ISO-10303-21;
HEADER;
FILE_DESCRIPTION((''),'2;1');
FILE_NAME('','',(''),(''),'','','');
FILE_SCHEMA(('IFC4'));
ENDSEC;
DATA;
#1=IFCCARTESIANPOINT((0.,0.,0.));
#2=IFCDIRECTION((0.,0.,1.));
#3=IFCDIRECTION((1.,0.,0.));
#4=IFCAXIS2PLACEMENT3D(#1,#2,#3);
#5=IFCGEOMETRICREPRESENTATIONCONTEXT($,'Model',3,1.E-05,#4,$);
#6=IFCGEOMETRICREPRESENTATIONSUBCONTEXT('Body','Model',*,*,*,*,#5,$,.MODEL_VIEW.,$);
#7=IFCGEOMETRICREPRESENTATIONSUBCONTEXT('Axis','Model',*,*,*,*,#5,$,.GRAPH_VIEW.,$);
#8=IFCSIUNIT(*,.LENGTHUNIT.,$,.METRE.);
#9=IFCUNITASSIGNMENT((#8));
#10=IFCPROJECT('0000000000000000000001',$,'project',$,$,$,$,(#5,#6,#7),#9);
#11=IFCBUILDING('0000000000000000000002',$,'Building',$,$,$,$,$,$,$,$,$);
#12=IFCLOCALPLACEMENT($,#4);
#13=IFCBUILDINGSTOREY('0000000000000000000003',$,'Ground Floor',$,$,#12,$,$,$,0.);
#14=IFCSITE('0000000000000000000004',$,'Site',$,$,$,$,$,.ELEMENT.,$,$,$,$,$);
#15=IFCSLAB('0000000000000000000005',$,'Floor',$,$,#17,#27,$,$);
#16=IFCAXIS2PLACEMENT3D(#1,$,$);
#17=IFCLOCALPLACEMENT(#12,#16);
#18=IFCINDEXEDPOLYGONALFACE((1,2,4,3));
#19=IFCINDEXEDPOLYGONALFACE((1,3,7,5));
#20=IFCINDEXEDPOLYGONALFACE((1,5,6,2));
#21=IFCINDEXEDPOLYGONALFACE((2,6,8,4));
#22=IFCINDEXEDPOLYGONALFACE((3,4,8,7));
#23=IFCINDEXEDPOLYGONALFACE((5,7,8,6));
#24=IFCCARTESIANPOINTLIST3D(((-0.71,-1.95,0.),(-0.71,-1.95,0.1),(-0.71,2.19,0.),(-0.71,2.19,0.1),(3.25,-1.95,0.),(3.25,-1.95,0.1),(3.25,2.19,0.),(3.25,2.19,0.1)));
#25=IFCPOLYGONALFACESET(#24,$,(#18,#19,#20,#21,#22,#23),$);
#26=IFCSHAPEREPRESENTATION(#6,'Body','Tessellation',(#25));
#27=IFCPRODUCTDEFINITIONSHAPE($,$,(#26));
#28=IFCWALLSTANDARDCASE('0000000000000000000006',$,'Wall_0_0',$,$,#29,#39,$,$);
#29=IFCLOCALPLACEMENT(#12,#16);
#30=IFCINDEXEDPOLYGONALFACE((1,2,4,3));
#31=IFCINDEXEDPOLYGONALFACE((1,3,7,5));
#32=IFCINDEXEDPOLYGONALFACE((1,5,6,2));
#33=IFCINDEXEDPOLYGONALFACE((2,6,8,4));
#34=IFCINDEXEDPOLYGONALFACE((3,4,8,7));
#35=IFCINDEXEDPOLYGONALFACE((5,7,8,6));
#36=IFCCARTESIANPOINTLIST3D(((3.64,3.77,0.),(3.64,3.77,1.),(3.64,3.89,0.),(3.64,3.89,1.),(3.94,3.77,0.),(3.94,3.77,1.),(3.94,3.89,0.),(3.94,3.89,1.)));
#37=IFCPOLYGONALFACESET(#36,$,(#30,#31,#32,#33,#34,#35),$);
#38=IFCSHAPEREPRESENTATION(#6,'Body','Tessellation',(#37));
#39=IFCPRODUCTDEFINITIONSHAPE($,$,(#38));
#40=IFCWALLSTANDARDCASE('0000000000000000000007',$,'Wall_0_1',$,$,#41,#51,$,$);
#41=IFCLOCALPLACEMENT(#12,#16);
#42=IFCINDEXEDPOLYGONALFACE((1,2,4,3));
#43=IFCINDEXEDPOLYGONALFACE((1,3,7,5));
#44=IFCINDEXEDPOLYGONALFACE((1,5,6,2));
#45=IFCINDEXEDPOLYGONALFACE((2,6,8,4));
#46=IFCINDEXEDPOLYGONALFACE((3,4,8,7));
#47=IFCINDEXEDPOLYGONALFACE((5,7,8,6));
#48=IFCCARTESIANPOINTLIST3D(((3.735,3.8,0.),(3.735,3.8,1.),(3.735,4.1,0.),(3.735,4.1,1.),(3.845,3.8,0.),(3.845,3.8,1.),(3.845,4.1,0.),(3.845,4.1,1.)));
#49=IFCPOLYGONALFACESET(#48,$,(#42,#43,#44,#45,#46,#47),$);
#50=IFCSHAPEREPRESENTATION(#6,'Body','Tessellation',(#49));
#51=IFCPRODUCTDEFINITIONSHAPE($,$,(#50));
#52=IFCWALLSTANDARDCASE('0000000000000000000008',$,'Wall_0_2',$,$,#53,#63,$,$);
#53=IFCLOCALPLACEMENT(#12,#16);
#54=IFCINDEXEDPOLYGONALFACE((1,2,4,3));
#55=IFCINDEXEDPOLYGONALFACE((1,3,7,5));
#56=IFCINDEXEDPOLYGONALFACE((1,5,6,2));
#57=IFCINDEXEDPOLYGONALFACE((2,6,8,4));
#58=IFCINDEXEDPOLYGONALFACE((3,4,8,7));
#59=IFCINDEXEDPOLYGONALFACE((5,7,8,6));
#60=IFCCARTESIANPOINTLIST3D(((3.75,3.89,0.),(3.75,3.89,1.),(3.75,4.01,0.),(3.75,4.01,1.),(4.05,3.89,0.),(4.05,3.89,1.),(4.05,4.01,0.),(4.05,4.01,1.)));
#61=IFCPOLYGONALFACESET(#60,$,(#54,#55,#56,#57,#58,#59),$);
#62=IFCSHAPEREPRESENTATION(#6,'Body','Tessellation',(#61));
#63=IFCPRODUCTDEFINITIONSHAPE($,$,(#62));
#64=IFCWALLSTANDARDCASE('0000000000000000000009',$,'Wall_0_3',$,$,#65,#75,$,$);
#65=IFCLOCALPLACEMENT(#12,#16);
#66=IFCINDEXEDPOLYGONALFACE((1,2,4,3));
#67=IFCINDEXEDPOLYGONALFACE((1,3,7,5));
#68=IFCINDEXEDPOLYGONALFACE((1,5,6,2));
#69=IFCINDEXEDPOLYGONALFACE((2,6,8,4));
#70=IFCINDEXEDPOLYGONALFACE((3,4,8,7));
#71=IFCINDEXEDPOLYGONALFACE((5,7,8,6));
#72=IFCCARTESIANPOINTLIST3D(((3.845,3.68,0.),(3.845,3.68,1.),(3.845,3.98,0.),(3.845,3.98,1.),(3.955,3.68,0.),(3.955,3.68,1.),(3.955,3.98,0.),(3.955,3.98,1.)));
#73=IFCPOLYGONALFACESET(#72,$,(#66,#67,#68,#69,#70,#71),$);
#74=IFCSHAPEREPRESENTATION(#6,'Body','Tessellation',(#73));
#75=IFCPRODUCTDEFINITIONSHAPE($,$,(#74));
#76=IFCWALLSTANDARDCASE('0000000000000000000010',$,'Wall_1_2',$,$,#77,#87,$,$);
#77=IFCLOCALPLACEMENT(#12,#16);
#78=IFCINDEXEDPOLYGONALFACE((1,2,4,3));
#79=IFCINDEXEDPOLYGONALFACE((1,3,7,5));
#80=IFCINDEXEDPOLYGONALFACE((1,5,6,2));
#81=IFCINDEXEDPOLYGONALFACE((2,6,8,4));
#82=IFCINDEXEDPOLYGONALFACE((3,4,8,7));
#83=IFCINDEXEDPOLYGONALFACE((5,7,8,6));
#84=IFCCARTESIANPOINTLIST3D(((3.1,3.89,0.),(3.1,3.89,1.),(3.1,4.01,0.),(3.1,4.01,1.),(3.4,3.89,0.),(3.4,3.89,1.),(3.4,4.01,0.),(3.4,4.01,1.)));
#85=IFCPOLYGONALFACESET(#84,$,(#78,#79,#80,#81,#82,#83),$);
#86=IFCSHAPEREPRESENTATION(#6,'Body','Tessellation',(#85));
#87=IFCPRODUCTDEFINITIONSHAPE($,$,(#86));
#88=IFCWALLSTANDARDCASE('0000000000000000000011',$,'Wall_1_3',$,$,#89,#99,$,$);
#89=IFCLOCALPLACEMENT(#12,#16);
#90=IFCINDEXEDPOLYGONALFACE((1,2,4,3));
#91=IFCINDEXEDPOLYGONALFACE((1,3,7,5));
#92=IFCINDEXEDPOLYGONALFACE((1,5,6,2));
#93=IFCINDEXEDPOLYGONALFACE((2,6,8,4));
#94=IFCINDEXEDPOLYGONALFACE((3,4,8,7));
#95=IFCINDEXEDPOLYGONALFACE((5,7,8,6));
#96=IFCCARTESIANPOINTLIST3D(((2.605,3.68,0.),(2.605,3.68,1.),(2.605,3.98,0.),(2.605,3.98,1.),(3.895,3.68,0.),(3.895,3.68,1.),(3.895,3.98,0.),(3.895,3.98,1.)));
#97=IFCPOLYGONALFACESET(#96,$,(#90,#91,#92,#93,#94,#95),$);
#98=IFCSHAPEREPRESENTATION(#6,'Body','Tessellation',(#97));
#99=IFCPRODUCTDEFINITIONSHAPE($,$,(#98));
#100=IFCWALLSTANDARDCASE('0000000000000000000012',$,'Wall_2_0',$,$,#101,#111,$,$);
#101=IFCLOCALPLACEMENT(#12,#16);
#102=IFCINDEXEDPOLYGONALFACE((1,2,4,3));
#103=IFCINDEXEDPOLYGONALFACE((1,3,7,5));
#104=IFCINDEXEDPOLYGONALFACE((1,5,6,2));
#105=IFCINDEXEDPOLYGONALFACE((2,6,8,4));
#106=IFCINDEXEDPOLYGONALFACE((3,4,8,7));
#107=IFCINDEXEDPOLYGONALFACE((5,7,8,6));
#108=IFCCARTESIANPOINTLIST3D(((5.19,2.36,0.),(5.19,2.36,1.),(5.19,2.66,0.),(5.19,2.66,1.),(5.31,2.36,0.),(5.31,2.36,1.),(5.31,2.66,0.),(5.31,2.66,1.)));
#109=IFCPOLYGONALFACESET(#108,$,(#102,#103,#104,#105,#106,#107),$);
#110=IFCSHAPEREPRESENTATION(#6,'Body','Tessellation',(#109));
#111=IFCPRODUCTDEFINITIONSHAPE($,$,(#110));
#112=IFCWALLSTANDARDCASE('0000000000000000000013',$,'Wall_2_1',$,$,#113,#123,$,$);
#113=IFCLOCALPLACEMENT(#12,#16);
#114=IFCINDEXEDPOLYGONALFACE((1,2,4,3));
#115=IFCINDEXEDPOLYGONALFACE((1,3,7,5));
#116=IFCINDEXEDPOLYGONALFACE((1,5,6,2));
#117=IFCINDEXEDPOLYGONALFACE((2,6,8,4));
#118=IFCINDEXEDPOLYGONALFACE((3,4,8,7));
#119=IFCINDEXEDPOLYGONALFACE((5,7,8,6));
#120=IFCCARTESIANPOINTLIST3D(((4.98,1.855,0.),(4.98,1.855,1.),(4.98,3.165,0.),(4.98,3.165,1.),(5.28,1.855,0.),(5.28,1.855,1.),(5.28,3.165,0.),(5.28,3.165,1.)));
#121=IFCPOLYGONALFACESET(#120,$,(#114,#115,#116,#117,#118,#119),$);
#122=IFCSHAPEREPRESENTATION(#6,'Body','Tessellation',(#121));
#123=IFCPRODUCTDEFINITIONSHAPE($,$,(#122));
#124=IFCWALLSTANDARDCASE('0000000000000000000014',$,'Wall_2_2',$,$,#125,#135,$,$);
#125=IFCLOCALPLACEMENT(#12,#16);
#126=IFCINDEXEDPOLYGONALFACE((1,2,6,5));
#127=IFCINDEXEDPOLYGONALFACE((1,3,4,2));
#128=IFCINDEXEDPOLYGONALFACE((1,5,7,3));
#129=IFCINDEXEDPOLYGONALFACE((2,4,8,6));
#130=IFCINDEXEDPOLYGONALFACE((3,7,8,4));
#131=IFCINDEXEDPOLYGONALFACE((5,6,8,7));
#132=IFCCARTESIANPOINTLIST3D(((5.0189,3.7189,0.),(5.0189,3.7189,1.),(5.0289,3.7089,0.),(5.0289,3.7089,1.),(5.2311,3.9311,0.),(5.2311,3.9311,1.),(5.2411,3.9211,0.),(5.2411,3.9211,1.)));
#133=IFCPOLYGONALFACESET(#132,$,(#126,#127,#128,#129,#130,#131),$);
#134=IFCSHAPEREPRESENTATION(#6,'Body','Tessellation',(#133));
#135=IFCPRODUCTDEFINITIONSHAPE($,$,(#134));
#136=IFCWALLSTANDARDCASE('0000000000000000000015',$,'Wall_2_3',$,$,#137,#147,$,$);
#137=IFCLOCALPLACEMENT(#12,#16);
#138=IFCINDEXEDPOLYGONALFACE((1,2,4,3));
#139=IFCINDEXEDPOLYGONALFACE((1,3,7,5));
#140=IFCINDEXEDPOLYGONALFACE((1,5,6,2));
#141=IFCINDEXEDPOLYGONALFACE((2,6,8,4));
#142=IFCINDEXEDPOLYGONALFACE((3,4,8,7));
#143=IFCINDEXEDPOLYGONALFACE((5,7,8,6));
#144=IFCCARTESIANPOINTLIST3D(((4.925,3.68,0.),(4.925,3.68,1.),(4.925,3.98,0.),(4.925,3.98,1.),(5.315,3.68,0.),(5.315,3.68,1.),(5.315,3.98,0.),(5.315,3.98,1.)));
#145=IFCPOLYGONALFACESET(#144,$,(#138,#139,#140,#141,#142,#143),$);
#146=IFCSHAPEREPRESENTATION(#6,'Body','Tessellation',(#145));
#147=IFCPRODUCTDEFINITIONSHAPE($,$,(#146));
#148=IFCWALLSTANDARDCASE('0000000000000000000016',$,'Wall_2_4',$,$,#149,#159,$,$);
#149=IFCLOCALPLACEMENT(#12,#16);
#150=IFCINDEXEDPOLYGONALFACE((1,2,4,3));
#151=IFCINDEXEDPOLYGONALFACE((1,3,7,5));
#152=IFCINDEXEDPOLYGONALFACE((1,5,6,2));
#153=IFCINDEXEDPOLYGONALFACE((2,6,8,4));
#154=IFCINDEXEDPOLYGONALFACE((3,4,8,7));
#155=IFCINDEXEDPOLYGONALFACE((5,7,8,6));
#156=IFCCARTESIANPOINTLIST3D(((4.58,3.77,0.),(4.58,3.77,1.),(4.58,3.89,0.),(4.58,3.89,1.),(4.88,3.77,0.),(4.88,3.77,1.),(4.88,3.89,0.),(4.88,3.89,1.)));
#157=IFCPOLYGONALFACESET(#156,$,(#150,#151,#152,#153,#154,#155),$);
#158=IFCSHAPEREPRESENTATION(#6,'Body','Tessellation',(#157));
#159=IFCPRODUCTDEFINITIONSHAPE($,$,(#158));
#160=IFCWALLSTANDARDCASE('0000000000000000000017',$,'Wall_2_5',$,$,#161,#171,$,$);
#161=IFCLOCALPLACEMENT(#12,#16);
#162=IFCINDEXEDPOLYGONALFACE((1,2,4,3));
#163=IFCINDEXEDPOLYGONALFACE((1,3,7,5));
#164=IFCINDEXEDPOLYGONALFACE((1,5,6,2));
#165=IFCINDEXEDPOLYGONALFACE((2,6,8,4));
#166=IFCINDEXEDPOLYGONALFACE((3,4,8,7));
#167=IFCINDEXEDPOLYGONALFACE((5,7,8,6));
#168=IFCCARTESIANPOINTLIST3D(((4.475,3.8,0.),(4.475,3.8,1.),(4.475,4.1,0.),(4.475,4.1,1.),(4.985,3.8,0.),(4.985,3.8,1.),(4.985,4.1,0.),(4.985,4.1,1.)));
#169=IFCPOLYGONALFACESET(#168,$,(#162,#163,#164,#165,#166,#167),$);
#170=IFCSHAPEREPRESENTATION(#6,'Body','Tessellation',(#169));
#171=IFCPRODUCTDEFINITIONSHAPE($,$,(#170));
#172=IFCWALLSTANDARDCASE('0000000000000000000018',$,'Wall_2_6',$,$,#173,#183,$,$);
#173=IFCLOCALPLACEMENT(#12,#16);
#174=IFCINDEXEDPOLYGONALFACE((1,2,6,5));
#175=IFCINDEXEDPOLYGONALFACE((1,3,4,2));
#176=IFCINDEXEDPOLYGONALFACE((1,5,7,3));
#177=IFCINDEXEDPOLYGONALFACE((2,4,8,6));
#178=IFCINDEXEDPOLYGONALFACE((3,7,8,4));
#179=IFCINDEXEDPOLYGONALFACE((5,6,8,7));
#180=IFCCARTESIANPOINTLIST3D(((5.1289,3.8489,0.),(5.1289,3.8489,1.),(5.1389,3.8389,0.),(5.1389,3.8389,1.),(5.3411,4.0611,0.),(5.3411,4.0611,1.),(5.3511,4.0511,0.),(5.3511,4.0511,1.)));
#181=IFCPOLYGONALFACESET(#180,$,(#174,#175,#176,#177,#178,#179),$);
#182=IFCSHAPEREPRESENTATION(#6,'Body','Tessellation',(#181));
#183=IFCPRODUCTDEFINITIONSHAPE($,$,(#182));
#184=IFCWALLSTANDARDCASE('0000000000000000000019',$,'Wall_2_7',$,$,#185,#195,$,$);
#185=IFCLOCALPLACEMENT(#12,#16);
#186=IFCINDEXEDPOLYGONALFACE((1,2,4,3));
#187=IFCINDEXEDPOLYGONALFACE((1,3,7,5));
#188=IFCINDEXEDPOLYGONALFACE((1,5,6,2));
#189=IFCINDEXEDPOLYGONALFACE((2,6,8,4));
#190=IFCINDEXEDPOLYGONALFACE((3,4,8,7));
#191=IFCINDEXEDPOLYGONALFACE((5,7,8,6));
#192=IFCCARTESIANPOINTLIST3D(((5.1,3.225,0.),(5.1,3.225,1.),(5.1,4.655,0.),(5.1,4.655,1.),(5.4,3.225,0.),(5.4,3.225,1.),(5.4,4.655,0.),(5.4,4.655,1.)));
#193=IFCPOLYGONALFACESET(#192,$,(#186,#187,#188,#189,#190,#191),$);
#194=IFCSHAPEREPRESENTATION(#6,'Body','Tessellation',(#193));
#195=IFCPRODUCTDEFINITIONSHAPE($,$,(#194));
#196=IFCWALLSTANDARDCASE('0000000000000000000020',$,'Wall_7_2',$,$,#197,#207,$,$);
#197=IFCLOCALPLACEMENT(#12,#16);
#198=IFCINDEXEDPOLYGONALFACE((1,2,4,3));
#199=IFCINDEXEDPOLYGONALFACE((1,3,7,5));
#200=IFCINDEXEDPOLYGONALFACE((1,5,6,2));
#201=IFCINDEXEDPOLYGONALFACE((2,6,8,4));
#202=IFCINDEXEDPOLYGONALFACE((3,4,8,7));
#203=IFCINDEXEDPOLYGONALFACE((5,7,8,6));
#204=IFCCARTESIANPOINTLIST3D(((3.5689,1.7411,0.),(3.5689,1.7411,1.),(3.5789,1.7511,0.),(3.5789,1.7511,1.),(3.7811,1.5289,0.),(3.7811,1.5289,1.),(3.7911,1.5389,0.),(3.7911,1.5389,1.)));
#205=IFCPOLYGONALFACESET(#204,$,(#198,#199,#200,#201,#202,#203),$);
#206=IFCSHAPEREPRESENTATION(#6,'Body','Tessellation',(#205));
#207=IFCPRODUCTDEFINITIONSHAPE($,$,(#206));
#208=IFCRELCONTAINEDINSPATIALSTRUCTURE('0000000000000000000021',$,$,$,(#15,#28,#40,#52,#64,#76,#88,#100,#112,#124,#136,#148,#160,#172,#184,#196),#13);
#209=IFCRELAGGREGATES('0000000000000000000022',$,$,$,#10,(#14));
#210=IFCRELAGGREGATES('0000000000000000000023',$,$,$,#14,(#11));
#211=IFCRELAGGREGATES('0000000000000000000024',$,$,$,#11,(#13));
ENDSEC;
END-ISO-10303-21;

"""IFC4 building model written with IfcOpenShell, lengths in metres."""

from ifc_helpers import new_model, si_unit, frame, frame_2d, origin_with_axes, origin_2d, place, context, subcontext, project, spatial, rectangle, extrude, element, save


model = new_model("IFC4")

# Units and contexts
model_context = context("Model", 3, precision=1e-05, world=origin_with_axes())
body_context = subcontext(model_context, "Body", "Model", "MODEL_VIEW")
axis_context = subcontext(model_context, "Axis", "Model", "GRAPH_VIEW")
ifc_project = project(units=[si_unit("LENGTHUNIT", "METRE")], contexts=[model_context, body_context, axis_context])

# Site, building, storey
site = spatial("IfcSite", under=ifc_project, Name="Site", CompositionType="ELEMENT")
building = spatial("IfcBuilding", under=site, Name="Building")
storey_placement = place(None, origin_with_axes())
storey = spatial("IfcBuildingStorey", under=building, at=storey_placement, Name="Ground Floor", Elevation=0.0)

# Slab
slab_placement = place(storey_placement, frame((3.25, 2.19, 0.0), z_axis=(0.0, 0.0, 1.0), x_axis=(1.0, 0.0, 0.0)))
element("IfcSlab", 1, at=slab_placement, inside=storey, Name="Floor", context=body_context, shape_type="SweptSolid", body=[
    extrude(rectangle(XDim=3.96, YDim=4.14, at=frame_2d((-1.98, -2.07))), origin_with_axes(), (0.0, 0.0, 1.0), 0.1),
])

# Walls
wall_1_placement = place(storey_placement, frame((3.79, 3.83, 0.0), z_axis=(0.0, 0.0, 1.0), x_axis=(0.0, 1.0, 0.0)))
element("IfcWallStandardCase", 2, at=wall_1_placement, inside=storey, Name="Wall_0_0", context=body_context, shape_type="SweptSolid", body=[
    extrude(rectangle(XDim=0.12, YDim=0.3, at=origin_2d()), origin_with_axes(), (0.0, 0.0, 1.0), 1.0),
])
wall_2_placement = place(storey_placement, frame((3.79, 3.95, 0.0), z_axis=(0.0, 0.0, 1.0), x_axis=(1.0, 0.0, 0.0)))
element("IfcWallStandardCase", 3, at=wall_2_placement, inside=storey, Name="Wall_0_1", context=body_context, shape_type="SweptSolid", body=[
    extrude(rectangle(XDim=0.11, YDim=0.3, at=origin_2d()), origin_with_axes(), (0.0, 0.0, 1.0), 1.0),
])
wall_3_placement = place(storey_placement, frame((3.9, 3.95, 0.0), z_axis=(0.0, 0.0, 1.0), x_axis=(0.0, -1.0, 0.0)))
element("IfcWallStandardCase", 4, at=wall_3_placement, inside=storey, Name="Wall_0_2", context=body_context, shape_type="SweptSolid", body=[
    extrude(rectangle(XDim=0.12, YDim=0.3, at=origin_2d()), origin_with_axes(), (0.0, 0.0, 1.0), 1.0),
])
wall_4_placement = place(storey_placement, frame((3.9, 3.83, 0.0), z_axis=(0.0, 0.0, 1.0), x_axis=(-1.0, 0.0, 0.0)))
element("IfcWallStandardCase", 5, at=wall_4_placement, inside=storey, Name="Wall_0_3", context=body_context, shape_type="SweptSolid", body=[
    extrude(rectangle(XDim=0.11, YDim=0.3, at=origin_2d()), origin_with_axes(), (0.0, 0.0, 1.0), 1.0),
])
wall_5_placement = place(storey_placement, frame((3.25, 3.95, 0.0), z_axis=(0.0, 0.0, 1.0), x_axis=(0.0, -1.0, 0.0)))
element("IfcWallStandardCase", 6, at=wall_5_placement, inside=storey, Name="Wall_1_2", context=body_context, shape_type="SweptSolid", body=[
    extrude(rectangle(XDim=0.12, YDim=0.3, at=origin_2d()), origin_with_axes(), (0.0, 0.0, 1.0), 1.0),
])
wall_6_placement = place(storey_placement, frame((3.25, 3.83, 0.0), z_axis=(0.0, 0.0, 1.0), x_axis=(-1.0, 0.0, 0.0)))
element("IfcWallStandardCase", 7, at=wall_6_placement, inside=storey, Name="Wall_1_3", context=body_context, shape_type="SweptSolid", body=[
    extrude(rectangle(XDim=1.29, YDim=0.3, at=origin_2d()), origin_with_axes(), (0.0, 0.0, 1.0), 1.0),
])
wall_7_placement = place(storey_placement, frame((5.25, 2.51, 0.0), z_axis=(0.0, 0.0, 1.0), x_axis=(-1.0, 0.0, 0.0)))
element("IfcWallStandardCase", 8, at=wall_7_placement, inside=storey, Name="Wall_2_0", context=body_context, shape_type="SweptSolid", body=[
    extrude(rectangle(XDim=0.12, YDim=0.3, at=origin_2d()), origin_with_axes(), (0.0, 0.0, 1.0), 1.0),
])
wall_8_placement = place(storey_placement, frame((5.13, 2.51, 0.0), z_axis=(0.0, 0.0, 1.0), x_axis=(0.0, 1.0, 0.0)))
element("IfcWallStandardCase", 9, at=wall_8_placement, inside=storey, Name="Wall_2_1", context=body_context, shape_type="SweptSolid", body=[
    extrude(rectangle(XDim=1.31, YDim=0.3, at=origin_2d()), origin_with_axes(), (0.0, 0.0, 1.0), 1.0),
])
wall_9_placement = place(storey_placement, frame((5.13, 3.82, 0.0), z_axis=(0.0, 0.0, 1.0), x_axis=(-0.707107, 0.707107, 0.0)))
element("IfcWallStandardCase", 10, at=wall_9_placement, inside=storey, Name="Wall_2_2", context=body_context, shape_type="SweptSolid", body=[
    extrude(rectangle(XDim=0.0141, YDim=0.3, at=origin_2d()), origin_with_axes(), (0.0, 0.0, 1.0), 1.0),
])
wall_10_placement = place(storey_placement, frame((5.12, 3.83, 0.0), z_axis=(0.0, 0.0, 1.0), x_axis=(-1.0, 0.0, 0.0)))
element("IfcWallStandardCase", 11, at=wall_10_placement, inside=storey, Name="Wall_2_3", context=body_context, shape_type="SweptSolid", body=[
    extrude(rectangle(XDim=0.39, YDim=0.3, at=origin_2d()), origin_with_axes(), (0.0, 0.0, 1.0), 1.0),
])
wall_11_placement = place(storey_placement, frame((4.73, 3.83, 0.0), z_axis=(0.0, 0.0, 1.0), x_axis=(0.0, 1.0, 0.0)))
element("IfcWallStandardCase", 12, at=wall_11_placement, inside=storey, Name="Wall_2_4", context=body_context, shape_type="SweptSolid", body=[
    extrude(rectangle(XDim=0.12, YDim=0.3, at=origin_2d()), origin_with_axes(), (0.0, 0.0, 1.0), 1.0),
])
wall_12_placement = place(storey_placement, frame((4.73, 3.95, 0.0), z_axis=(0.0, 0.0, 1.0), x_axis=(1.0, 0.0, 0.0)))
element("IfcWallStandardCase", 13, at=wall_12_placement, inside=storey, Name="Wall_2_5", context=body_context, shape_type="SweptSolid", body=[
    extrude(rectangle(XDim=0.51, YDim=0.3, at=origin_2d()), origin_with_axes(), (0.0, 0.0, 1.0), 1.0),
])
wall_13_placement = place(storey_placement, frame((5.24, 3.95, 0.0), z_axis=(0.0, 0.0, 1.0), x_axis=(0.707107, -0.707107, 0.0)))
element("IfcWallStandardCase", 14, at=wall_13_placement, inside=storey, Name="Wall_2_6", context=body_context, shape_type="SweptSolid", body=[
    extrude(rectangle(XDim=0.0141, YDim=0.3, at=origin_2d()), origin_with_axes(), (0.0, 0.0, 1.0), 1.0),
])
wall_14_placement = place(storey_placement, frame((5.25, 3.94, 0.0), z_axis=(0.0, 0.0, 1.0), x_axis=(0.0, -1.0, 0.0)))
element("IfcWallStandardCase", 15, at=wall_14_placement, inside=storey, Name="Wall_2_7", context=body_context, shape_type="SweptSolid", body=[
    extrude(rectangle(XDim=1.43, YDim=0.3, at=origin_2d()), origin_with_axes(), (0.0, 0.0, 1.0), 1.0),
])
wall_15_placement = place(storey_placement, frame((3.68, 1.64, 0.0), z_axis=(0.0, 0.0, 1.0), x_axis=(0.707107, 0.707107, 0.0)))
element("IfcWallStandardCase", 16, at=wall_15_placement, inside=storey, Name="Wall_7_2", context=body_context, shape_type="SweptSolid", body=[
    extrude(rectangle(XDim=0.0141, YDim=0.3, at=origin_2d()), origin_with_axes(), (0.0, 0.0, 1.0), 1.0),
])

save(model, "model.ifc")
